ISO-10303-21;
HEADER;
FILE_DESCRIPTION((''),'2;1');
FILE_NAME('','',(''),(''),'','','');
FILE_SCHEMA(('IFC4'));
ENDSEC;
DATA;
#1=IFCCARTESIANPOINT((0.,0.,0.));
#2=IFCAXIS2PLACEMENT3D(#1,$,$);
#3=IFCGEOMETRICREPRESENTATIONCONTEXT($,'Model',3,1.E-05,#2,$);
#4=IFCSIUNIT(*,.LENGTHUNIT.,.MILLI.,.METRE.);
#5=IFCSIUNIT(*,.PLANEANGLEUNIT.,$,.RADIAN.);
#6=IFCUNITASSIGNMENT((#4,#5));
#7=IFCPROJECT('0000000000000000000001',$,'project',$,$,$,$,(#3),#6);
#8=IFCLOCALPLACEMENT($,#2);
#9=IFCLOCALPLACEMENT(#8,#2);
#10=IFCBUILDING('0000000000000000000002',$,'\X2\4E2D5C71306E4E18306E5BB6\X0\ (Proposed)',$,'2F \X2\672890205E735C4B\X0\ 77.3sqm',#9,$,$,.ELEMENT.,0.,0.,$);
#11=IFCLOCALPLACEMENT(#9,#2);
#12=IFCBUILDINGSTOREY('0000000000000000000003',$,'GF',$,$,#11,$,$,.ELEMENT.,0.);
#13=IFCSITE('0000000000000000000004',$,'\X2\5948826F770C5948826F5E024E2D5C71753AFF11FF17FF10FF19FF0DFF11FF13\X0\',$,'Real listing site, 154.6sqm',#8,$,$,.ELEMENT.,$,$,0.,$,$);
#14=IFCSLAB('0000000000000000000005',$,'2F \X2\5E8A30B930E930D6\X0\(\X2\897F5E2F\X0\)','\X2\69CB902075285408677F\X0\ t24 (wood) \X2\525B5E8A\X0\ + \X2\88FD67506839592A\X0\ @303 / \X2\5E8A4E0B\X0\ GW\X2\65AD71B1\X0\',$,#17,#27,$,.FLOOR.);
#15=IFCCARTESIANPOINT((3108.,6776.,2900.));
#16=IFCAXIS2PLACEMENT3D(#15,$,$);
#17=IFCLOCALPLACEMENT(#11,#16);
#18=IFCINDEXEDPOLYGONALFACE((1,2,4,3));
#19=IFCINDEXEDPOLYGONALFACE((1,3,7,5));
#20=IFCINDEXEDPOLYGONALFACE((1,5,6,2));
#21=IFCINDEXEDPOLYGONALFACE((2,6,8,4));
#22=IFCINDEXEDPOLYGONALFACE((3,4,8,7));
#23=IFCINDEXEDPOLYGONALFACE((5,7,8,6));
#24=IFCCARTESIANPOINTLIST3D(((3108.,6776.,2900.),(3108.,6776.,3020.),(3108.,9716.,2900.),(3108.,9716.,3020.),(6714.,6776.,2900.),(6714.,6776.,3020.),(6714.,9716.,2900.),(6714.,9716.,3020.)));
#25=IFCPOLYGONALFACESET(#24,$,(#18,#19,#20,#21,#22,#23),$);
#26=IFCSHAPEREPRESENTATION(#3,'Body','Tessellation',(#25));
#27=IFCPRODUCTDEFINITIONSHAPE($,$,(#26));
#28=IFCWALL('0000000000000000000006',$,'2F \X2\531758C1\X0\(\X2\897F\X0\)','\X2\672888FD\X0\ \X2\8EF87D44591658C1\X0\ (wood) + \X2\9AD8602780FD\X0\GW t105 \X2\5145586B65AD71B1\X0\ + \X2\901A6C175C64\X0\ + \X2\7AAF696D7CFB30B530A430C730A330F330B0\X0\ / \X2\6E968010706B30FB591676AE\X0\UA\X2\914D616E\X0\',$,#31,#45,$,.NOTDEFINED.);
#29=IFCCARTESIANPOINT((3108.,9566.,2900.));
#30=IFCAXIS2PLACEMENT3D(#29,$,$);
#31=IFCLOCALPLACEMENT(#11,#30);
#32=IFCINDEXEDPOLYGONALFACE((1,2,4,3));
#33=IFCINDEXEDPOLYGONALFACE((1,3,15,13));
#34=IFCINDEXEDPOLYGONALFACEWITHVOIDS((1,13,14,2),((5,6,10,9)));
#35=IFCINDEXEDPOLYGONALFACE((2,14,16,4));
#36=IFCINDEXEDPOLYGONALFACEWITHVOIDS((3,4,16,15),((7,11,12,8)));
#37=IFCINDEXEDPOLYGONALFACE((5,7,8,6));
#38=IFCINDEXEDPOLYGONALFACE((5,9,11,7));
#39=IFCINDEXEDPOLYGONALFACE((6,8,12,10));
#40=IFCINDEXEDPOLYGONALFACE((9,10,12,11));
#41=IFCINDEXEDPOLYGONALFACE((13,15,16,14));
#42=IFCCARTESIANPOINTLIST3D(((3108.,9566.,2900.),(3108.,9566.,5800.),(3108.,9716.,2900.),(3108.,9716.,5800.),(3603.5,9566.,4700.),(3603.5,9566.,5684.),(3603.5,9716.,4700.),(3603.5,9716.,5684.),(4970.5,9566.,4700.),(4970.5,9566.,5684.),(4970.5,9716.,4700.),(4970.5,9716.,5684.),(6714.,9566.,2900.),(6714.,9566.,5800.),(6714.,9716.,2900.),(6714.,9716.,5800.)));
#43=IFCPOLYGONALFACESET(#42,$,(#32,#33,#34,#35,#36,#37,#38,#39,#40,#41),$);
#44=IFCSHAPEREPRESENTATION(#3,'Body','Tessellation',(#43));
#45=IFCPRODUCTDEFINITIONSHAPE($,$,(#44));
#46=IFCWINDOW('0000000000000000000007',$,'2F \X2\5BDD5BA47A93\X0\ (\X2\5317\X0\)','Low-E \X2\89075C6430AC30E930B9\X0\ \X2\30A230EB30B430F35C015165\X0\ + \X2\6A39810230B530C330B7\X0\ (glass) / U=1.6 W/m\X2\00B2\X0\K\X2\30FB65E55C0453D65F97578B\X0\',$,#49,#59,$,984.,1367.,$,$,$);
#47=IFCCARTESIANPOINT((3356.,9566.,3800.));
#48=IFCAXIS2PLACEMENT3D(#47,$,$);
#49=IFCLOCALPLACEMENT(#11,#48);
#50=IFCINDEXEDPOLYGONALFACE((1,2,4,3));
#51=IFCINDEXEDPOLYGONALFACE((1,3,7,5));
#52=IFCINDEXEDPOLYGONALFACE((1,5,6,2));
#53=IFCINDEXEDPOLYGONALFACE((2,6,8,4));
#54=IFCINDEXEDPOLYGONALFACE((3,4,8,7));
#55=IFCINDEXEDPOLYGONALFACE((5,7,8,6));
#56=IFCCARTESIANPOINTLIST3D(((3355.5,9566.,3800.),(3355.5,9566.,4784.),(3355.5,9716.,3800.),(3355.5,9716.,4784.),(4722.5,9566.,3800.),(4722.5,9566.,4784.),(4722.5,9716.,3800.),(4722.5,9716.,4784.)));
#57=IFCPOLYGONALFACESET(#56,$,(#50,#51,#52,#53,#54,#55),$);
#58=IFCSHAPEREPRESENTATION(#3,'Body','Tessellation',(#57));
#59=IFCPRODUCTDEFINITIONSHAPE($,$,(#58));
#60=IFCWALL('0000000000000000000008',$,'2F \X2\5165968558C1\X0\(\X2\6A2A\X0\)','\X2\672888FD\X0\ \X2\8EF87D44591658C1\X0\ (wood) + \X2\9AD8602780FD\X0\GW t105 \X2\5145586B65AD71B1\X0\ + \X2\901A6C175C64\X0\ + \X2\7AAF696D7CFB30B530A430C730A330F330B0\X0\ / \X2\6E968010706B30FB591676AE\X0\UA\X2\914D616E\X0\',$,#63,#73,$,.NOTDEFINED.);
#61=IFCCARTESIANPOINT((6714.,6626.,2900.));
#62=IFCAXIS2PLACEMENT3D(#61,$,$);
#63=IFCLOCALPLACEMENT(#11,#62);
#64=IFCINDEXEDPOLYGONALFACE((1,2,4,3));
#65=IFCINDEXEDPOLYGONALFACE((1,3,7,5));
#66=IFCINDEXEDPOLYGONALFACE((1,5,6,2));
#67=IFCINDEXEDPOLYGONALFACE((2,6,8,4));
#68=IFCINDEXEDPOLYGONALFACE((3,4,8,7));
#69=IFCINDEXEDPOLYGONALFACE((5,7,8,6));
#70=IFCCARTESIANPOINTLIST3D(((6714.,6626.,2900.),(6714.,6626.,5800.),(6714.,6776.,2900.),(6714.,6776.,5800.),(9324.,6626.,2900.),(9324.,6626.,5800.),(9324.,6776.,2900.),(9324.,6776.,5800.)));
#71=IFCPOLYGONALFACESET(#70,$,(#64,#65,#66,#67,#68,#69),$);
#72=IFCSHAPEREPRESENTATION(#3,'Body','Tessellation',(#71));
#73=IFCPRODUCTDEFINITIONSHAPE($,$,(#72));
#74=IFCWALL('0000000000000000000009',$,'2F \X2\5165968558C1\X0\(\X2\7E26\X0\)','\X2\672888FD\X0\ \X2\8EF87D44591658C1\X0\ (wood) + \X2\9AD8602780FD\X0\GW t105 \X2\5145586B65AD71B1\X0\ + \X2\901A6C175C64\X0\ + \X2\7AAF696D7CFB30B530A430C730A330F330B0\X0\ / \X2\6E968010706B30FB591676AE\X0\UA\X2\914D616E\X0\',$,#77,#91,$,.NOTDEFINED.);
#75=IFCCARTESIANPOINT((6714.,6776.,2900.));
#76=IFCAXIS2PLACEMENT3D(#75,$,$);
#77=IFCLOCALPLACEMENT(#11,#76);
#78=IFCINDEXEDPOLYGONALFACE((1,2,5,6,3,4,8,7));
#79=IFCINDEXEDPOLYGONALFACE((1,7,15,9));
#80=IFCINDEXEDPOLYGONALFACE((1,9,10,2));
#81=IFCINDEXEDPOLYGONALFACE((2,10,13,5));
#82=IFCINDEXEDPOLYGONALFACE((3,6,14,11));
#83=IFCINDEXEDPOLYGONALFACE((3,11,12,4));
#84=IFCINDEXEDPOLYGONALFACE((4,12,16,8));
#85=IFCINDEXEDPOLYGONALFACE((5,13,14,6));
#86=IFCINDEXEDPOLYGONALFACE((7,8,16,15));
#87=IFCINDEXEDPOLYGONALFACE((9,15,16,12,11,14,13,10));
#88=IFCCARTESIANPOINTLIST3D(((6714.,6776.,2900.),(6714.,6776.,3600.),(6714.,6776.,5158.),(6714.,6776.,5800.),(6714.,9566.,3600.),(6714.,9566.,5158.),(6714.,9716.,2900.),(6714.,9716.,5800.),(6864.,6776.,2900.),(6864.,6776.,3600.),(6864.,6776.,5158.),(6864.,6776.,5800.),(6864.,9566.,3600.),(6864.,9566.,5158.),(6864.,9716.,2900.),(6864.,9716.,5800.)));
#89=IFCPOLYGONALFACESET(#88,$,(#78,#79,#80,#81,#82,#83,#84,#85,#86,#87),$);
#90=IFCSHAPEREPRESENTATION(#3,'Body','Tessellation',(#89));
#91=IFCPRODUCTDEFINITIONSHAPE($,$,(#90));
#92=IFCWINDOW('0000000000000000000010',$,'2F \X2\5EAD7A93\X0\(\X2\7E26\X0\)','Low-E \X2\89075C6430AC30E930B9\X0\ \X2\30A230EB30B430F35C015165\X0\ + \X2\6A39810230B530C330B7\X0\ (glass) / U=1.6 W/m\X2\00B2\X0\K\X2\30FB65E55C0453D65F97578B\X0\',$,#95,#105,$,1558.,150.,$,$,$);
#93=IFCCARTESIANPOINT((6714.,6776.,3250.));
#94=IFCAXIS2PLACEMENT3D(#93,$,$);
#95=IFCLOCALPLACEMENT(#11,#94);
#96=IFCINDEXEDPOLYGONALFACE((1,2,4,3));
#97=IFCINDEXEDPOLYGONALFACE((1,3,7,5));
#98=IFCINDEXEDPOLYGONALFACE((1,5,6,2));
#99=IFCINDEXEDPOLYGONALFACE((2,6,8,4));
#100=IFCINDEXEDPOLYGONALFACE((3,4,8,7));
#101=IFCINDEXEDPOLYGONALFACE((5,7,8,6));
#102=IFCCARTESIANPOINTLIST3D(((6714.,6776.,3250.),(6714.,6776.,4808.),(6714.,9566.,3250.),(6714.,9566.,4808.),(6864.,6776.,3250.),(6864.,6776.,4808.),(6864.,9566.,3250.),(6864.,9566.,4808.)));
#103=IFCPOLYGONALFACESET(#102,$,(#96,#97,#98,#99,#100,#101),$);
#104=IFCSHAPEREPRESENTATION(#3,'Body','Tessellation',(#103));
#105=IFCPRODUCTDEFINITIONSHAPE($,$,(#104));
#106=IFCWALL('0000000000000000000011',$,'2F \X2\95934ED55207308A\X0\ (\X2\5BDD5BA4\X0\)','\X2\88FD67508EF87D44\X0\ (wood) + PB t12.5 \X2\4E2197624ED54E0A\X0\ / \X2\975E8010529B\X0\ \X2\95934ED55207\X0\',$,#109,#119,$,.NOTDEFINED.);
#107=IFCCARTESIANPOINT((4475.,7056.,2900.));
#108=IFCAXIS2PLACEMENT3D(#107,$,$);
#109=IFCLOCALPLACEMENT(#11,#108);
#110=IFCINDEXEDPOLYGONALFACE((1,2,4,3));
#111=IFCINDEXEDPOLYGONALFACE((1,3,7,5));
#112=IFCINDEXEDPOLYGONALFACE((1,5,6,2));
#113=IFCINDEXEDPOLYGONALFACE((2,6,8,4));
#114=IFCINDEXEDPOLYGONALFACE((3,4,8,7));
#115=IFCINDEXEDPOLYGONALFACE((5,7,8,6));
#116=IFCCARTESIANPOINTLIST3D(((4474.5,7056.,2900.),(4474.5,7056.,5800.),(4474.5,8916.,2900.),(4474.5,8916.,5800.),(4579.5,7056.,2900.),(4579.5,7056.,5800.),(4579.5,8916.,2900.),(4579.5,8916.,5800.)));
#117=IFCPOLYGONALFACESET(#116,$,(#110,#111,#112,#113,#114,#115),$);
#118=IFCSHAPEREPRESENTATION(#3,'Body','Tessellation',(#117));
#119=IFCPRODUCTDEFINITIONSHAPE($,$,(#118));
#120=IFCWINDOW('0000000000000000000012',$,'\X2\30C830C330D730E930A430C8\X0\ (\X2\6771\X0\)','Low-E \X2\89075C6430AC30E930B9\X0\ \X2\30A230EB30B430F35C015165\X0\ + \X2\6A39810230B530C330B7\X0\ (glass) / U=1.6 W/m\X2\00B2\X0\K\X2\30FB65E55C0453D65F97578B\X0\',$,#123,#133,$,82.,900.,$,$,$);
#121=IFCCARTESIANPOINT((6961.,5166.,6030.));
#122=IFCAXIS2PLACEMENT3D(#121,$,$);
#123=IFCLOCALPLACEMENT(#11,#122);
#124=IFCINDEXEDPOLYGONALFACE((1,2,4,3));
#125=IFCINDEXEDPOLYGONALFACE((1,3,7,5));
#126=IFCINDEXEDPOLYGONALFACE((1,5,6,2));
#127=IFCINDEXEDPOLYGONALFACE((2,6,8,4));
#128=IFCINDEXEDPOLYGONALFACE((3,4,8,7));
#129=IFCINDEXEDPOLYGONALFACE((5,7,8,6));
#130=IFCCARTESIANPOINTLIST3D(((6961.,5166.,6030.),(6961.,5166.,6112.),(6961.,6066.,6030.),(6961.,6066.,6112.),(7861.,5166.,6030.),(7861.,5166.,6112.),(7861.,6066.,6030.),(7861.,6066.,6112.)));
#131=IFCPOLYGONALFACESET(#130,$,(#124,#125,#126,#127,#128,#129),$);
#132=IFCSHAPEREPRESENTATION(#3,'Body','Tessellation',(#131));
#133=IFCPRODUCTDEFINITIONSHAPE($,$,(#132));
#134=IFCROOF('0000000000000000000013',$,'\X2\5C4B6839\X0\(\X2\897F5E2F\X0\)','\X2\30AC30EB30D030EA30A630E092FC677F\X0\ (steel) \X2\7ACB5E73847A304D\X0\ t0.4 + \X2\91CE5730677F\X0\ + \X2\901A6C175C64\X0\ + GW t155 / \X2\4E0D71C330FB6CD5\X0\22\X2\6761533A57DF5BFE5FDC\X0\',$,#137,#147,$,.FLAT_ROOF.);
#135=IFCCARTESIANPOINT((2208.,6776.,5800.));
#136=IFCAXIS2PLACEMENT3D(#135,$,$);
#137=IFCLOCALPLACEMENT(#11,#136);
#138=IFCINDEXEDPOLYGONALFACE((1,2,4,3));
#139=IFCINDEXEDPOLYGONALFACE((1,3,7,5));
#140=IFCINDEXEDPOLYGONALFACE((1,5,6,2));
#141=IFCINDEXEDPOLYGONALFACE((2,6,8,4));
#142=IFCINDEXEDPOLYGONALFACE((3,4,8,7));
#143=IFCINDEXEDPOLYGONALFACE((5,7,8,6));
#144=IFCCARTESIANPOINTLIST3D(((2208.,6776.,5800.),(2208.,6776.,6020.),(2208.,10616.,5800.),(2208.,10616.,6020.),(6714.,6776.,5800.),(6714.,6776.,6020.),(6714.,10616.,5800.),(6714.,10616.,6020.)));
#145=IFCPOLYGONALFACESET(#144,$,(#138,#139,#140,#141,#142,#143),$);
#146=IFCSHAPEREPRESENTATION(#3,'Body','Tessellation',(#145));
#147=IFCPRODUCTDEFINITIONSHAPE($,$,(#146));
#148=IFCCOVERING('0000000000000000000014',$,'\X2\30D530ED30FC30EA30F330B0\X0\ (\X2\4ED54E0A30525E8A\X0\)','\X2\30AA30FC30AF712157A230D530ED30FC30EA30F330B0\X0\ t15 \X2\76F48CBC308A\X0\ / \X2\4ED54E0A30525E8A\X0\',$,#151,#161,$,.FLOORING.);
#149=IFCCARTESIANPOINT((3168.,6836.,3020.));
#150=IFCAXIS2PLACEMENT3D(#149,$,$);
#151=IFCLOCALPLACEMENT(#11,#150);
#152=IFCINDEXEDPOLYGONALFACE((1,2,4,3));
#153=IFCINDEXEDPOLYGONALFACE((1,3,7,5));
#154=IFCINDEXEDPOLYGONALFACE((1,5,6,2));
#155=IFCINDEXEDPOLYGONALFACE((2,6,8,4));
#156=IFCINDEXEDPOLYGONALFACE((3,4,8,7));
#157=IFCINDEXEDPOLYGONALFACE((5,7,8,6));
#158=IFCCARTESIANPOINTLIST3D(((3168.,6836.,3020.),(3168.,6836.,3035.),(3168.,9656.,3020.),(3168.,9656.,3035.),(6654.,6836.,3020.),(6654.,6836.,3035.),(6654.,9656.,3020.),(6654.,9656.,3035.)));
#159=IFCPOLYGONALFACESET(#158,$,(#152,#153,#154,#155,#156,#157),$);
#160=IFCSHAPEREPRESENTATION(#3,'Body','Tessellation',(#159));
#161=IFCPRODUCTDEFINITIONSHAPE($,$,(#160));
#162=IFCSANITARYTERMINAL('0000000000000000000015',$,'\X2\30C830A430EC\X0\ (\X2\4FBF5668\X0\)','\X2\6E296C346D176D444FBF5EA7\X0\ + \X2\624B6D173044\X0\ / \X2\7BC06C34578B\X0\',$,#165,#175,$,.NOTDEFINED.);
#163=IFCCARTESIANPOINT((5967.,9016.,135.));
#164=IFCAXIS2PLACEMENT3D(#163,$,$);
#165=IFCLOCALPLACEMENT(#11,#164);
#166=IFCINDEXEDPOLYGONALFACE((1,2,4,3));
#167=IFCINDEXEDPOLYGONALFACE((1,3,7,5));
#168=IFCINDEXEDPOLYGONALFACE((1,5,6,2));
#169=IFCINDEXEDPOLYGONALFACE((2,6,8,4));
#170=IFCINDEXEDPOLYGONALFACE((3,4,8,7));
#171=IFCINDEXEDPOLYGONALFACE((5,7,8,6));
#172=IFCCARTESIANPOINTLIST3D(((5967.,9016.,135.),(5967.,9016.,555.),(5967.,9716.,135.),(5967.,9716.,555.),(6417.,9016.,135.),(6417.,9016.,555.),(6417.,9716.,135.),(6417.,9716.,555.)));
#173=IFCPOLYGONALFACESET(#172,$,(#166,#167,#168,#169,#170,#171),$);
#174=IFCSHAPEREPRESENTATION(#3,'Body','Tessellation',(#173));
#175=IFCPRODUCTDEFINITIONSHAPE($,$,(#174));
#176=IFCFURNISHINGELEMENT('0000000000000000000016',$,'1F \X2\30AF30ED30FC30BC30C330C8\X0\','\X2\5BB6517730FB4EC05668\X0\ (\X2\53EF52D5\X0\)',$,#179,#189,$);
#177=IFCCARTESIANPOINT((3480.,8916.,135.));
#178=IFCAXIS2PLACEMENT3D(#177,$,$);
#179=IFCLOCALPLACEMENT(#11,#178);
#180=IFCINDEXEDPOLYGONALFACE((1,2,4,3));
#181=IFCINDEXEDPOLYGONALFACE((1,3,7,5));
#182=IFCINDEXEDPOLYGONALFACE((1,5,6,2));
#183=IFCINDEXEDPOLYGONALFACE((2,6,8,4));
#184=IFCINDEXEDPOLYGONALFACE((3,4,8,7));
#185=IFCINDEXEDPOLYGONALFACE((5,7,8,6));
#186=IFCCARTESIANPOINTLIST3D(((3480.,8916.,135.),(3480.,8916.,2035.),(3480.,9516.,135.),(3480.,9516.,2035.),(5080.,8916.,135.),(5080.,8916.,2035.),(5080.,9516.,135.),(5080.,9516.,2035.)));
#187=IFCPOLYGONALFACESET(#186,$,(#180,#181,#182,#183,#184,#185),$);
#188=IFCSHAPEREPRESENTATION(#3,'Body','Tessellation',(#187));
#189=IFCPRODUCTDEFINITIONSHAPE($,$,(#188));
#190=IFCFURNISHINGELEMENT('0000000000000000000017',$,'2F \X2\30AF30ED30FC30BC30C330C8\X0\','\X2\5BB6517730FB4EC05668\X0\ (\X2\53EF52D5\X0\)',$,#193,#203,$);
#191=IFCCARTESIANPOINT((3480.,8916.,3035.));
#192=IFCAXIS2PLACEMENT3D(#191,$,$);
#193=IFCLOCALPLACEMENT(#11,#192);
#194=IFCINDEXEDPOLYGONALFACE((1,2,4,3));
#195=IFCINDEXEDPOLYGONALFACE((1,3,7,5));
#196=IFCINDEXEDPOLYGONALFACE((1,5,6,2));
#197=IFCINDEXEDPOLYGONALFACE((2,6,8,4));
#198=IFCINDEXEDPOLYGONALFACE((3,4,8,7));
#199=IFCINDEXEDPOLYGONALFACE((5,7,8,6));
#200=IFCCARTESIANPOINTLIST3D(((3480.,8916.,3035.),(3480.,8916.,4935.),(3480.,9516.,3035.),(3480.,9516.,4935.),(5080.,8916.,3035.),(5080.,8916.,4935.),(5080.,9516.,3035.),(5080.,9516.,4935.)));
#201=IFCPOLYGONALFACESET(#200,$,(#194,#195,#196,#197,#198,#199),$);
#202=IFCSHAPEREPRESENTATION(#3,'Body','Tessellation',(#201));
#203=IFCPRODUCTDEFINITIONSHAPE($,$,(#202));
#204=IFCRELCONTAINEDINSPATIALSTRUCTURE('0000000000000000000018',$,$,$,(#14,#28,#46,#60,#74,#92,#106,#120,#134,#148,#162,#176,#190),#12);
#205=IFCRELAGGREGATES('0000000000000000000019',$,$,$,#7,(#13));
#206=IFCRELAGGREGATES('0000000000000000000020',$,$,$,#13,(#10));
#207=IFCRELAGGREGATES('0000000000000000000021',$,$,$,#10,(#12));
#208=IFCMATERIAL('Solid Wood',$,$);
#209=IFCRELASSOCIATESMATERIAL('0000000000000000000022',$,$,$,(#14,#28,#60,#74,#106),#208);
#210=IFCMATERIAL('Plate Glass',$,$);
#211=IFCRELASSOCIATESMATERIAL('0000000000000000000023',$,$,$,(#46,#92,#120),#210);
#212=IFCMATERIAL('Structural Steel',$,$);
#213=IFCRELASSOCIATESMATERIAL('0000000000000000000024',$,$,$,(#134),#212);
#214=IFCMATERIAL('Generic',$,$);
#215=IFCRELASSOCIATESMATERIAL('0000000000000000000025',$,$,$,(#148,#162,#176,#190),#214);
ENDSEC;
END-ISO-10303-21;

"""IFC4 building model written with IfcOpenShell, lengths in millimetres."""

from ifc_helpers import new_model, si_unit, frame, frame_2d, origin, place, context, project, spatial, rectangle, extrude, material, element, fill, save


model = new_model("IFC4")

# Units and contexts
model_context = context("Model", 3, precision=1e-05, world=origin())
ifc_project = project(units=[si_unit("LENGTHUNIT", "METRE", prefix="MILLI"), si_unit("PLANEANGLEUNIT", "RADIAN")], contexts=[model_context])

# Site, building, storey
site_placement = place(None, origin())
site = spatial("IfcSite", under=ifc_project, at=site_placement, Name="奈良県奈良市中山町１７０９－１３", ObjectType="Real listing site, 154.6sqm", CompositionType="ELEMENT", RefElevation=0.0)
building_placement = place(site_placement, origin())
building = spatial("IfcBuilding", under=site, at=building_placement, Name="中山の丘の家 (Proposed)", ObjectType="2F 木造平屋 77.3sqm", CompositionType="ELEMENT", ElevationOfRefHeight=0.0, ElevationOfTerrain=0.0)
storey_placement = place(building_placement, origin())
storey = spatial("IfcBuildingStorey", under=building, at=storey_placement, Name="GF", CompositionType="ELEMENT", Elevation=0.0)

# Slab
ifc_material_1 = material(Name="Solid Wood")
slab_placement = place(storey_placement, frame((3108.0, 6776.0, 2900.0)))
element("IfcSlab", 1, at=slab_placement, inside=storey, material=ifc_material_1, Name="2F 床スラブ(西帯)", Description="構造用合板 t24 (wood) 剛床 + 製材根太 @303 / 床下 GW断熱", PredefinedType="FLOOR", context=model_context, shape_type="SweptSolid", body=[
    extrude(rectangle(XDim=3606.0, YDim=2940.0, at=frame_2d((1803.0, 1470.0))), frame((3108.0, 6776.0, 2900.0)), (0.0, 0.0, 1.0), 120.0),
])

# Wall, opening, window
wall_1_placement = place(storey_placement, frame((3108.0, 9566.0, 2900.0)))
wall_1 = element("IfcWall", 2, at=wall_1_placement, inside=storey, material=ifc_material_1, Name="2F 北壁(西)", Description="木製 軸組外壁 (wood) + 高性能GW t105 充填断熱 + 通気層 + 窯業系サイディング / 準耐火・外皮UA配慮", PredefinedType="NOTDEFINED", context=model_context, shape_type="SweptSolid", body=[
    extrude(rectangle(XDim=3606.0, YDim=150.0, at=frame_2d((1803.0, 75.0))), frame((3108.0, 9566.0, 2900.0)), (0.0, 0.0, 1.0), 2900.0),
])
opening_1_placement = place(storey_placement, frame((3356.0, 9566.0, 3800.0)))
opening_1 = element("IfcOpeningElement", 3, at=opening_1_placement, cuts=wall_1, PredefinedType="NOTDEFINED", context=model_context, shape_type="SweptSolid", body=[
    extrude(rectangle(XDim=1367.0, YDim=150.0, at=frame_2d((683.0, 75.0))), frame((3356.0, 9566.0, 3800.0)), (0.0, 0.0, 1.0), 984.0),
])
ifc_material_2 = material(Name="Plate Glass")
window_1_placement = place(storey_placement, frame((3356.0, 9566.0, 3800.0)))
window_1 = element("IfcWindow", 4, at=window_1_placement, inside=storey, material=ifc_material_2, Name="2F 寝室窓 (北)", Description="Low-E 複層ガラス アルゴン封入 + 樹脂サッシ (glass) / U=1.6 W/m²K・日射取得型", OverallHeight=984.0, OverallWidth=1367.0, context=model_context, shape_type="SweptSolid", body=[
    extrude(rectangle(XDim=1367.0, YDim=150.0, at=frame_2d((683.0, 75.0))), frame((3356.0, 9566.0, 3800.0)), (0.0, 0.0, 1.0), 984.0),
])
fill(opening_1, window_1)

# Wall
wall_2_placement = place(storey_placement, frame((6714.0, 6626.0, 2900.0)))
element("IfcWall", 5, at=wall_2_placement, inside=storey, material=ifc_material_1, Name="2F 入隅壁(横)", Description="木製 軸組外壁 (wood) + 高性能GW t105 充填断熱 + 通気層 + 窯業系サイディング / 準耐火・外皮UA配慮", PredefinedType="NOTDEFINED", context=model_context, shape_type="SweptSolid", body=[
    extrude(rectangle(XDim=2610.0, YDim=150.0, at=frame_2d((1305.0, 75.0))), frame((6714.0, 6626.0, 2900.0)), (0.0, 0.0, 1.0), 2900.0),
])

# Wall, opening, window
wall_3_placement = place(storey_placement, frame((6714.0, 6776.0, 2900.0)))
wall_3 = element("IfcWall", 6, at=wall_3_placement, inside=storey, material=ifc_material_1, Name="2F 入隅壁(縦)", Description="木製 軸組外壁 (wood) + 高性能GW t105 充填断熱 + 通気層 + 窯業系サイディング / 準耐火・外皮UA配慮", PredefinedType="NOTDEFINED", context=model_context, shape_type="SweptSolid", body=[
    extrude(rectangle(XDim=150.0, YDim=2940.0, at=frame_2d((75.0, 1470.0))), frame((6714.0, 6776.0, 2900.0)), (0.0, 0.0, 1.0), 2900.0),
])
opening_2_placement = place(storey_placement, frame((6714.0, 6776.0, 3250.0)))
opening_2 = element("IfcOpeningElement", 7, at=opening_2_placement, cuts=wall_3, PredefinedType="NOTDEFINED", context=model_context, shape_type="SweptSolid", body=[
    extrude(rectangle(XDim=150.0, YDim=2790.0, at=frame_2d((75.0, 1395.0))), frame((6714.0, 6776.0, 3250.0)), (0.0, 0.0, 1.0), 1558.0),
])
window_2_placement = place(storey_placement, frame((6714.0, 6776.0, 3250.0)))
window_2 = element("IfcWindow", 8, at=window_2_placement, inside=storey, material=ifc_material_2, Name="2F 庭窓(縦)", Description="Low-E 複層ガラス アルゴン封入 + 樹脂サッシ (glass) / U=1.6 W/m²K・日射取得型", OverallHeight=1558.0, OverallWidth=150.0, context=model_context, shape_type="SweptSolid", body=[
    extrude(rectangle(XDim=150.0, YDim=2790.0, at=frame_2d((75.0, 1395.0))), frame((6714.0, 6776.0, 3250.0)), (0.0, 0.0, 1.0), 1558.0),
])
fill(opening_2, window_2)

# Wall
wall_4_placement = place(storey_placement, frame((4475.0, 7056.0, 2900.0)))
element("IfcWall", 9, at=wall_4_placement, inside=storey, material=ifc_material_1, Name="2F 間仕切り (寝室)", Description="製材軸組 (wood) + PB t12.5 両面仕上 / 非耐力 間仕切", PredefinedType="NOTDEFINED", context=model_context, shape_type="SweptSolid", body=[
    extrude(rectangle(XDim=105.0, YDim=1860.0, at=frame_2d((52.0, 930.0))), frame((4475.0, 7056.0, 2900.0)), (0.0, 0.0, 1.0), 2900.0),
])

# Window
window_3_placement = place(storey_placement, frame((6961.0, 5166.0, 6030.0)))
element("IfcWindow", 10, at=window_3_placement, inside=storey, material=ifc_material_2, Name="トップライト (東)", Description="Low-E 複層ガラス アルゴン封入 + 樹脂サッシ (glass) / U=1.6 W/m²K・日射取得型", OverallHeight=82.0, OverallWidth=900.0, context=model_context, shape_type="SweptSolid", body=[
    extrude(rectangle(XDim=900.0, YDim=900.0, at=frame_2d((450.0, 450.0))), frame((6961.0, 5166.0, 6030.0)), (0.0, 0.0, 1.0), 82.0),
])

# Roof
ifc_material_3 = material(Name="Structural Steel")
for number, where, name in (
    (11, (2208.0, 6776.0, 5800.0), "屋根(西帯)"),
):
    element("IfcRoof", number, at=place(storey_placement, frame(where)), inside=storey, material=ifc_material_3, Name=name, Description="ガルバリウム鋼板 (steel) 立平葺き t0.4 + 野地板 + 通気層 + GW t155 / 不燃・法22条区域対応", PredefinedType="FLAT_ROOF", context=model_context, shape_type="SweptSolid", body=[
        extrude(rectangle(XDim=4506.0, YDim=3840.0, at=frame_2d((2253.0, 1920.0))), frame((2208.0, 6776.0, 5800.0)), (0.0, 0.0, 1.0), 220.0),
    ])

# Covering
ifc_material_4 = material(Name="Generic")
covering_placement = place(storey_placement, frame((3168.0, 6836.0, 3020.0)))
element("IfcCovering", 12, at=covering_placement, inside=storey, material=ifc_material_4, Name="フローリング (仕上げ床)", Description="オーク無垢フローリング t15 直貼り / 仕上げ床", PredefinedType="FLOORING", context=model_context, shape_type="SweptSolid", body=[
    extrude(rectangle(XDim=3486.0, YDim=2820.0, at=frame_2d((1743.0, 1410.0))), frame((3168.0, 6836.0, 3020.0)), (0.0, 0.0, 1.0), 15.0),
])

# Sanitary terminal
sanitary_terminal_placement = place(storey_placement, frame((5967.0, 9016.0, 135.0)))
element("IfcSanitaryTerminal", 13, at=sanitary_terminal_placement, inside=storey, material=ifc_material_4, Name="トイレ (便器)", Description="温水洗浄便座 + 手洗い / 節水型", PredefinedType="NOTDEFINED", context=model_context, shape_type="SweptSolid", body=[
    extrude(rectangle(XDim=450.0, YDim=700.0, at=frame_2d((225.0, 350.0))), frame((5967.0, 9016.0, 135.0)), (0.0, 0.0, 1.0), 420.0),
])

# Furnishing elements
furnishing_1_placement = place(storey_placement, frame((3480.0, 8916.0, 135.0)))
element("IfcFurnishingElement", 14, at=furnishing_1_placement, inside=storey, material=ifc_material_4, Name="1F クローゼット", Description="家具・什器 (可動)", context=model_context, shape_type="SweptSolid", body=[
    extrude(rectangle(XDim=1600.0, YDim=600.0, at=frame_2d((800.0, 300.0))), frame((3480.0, 8916.0, 135.0)), (0.0, 0.0, 1.0), 1900.0),
])
furnishing_2_placement = place(storey_placement, frame((3480.0, 8916.0, 3035.0)))
element("IfcFurnishingElement", 15, at=furnishing_2_placement, inside=storey, material=ifc_material_4, Name="2F クローゼット", Description="家具・什器 (可動)", context=model_context, shape_type="SweptSolid", body=[
    extrude(rectangle(XDim=1600.0, YDim=600.0, at=frame_2d((800.0, 300.0))), frame((3480.0, 8916.0, 3035.0)), (0.0, 0.0, 1.0), 1900.0),
])

save(model, "model.ifc")
